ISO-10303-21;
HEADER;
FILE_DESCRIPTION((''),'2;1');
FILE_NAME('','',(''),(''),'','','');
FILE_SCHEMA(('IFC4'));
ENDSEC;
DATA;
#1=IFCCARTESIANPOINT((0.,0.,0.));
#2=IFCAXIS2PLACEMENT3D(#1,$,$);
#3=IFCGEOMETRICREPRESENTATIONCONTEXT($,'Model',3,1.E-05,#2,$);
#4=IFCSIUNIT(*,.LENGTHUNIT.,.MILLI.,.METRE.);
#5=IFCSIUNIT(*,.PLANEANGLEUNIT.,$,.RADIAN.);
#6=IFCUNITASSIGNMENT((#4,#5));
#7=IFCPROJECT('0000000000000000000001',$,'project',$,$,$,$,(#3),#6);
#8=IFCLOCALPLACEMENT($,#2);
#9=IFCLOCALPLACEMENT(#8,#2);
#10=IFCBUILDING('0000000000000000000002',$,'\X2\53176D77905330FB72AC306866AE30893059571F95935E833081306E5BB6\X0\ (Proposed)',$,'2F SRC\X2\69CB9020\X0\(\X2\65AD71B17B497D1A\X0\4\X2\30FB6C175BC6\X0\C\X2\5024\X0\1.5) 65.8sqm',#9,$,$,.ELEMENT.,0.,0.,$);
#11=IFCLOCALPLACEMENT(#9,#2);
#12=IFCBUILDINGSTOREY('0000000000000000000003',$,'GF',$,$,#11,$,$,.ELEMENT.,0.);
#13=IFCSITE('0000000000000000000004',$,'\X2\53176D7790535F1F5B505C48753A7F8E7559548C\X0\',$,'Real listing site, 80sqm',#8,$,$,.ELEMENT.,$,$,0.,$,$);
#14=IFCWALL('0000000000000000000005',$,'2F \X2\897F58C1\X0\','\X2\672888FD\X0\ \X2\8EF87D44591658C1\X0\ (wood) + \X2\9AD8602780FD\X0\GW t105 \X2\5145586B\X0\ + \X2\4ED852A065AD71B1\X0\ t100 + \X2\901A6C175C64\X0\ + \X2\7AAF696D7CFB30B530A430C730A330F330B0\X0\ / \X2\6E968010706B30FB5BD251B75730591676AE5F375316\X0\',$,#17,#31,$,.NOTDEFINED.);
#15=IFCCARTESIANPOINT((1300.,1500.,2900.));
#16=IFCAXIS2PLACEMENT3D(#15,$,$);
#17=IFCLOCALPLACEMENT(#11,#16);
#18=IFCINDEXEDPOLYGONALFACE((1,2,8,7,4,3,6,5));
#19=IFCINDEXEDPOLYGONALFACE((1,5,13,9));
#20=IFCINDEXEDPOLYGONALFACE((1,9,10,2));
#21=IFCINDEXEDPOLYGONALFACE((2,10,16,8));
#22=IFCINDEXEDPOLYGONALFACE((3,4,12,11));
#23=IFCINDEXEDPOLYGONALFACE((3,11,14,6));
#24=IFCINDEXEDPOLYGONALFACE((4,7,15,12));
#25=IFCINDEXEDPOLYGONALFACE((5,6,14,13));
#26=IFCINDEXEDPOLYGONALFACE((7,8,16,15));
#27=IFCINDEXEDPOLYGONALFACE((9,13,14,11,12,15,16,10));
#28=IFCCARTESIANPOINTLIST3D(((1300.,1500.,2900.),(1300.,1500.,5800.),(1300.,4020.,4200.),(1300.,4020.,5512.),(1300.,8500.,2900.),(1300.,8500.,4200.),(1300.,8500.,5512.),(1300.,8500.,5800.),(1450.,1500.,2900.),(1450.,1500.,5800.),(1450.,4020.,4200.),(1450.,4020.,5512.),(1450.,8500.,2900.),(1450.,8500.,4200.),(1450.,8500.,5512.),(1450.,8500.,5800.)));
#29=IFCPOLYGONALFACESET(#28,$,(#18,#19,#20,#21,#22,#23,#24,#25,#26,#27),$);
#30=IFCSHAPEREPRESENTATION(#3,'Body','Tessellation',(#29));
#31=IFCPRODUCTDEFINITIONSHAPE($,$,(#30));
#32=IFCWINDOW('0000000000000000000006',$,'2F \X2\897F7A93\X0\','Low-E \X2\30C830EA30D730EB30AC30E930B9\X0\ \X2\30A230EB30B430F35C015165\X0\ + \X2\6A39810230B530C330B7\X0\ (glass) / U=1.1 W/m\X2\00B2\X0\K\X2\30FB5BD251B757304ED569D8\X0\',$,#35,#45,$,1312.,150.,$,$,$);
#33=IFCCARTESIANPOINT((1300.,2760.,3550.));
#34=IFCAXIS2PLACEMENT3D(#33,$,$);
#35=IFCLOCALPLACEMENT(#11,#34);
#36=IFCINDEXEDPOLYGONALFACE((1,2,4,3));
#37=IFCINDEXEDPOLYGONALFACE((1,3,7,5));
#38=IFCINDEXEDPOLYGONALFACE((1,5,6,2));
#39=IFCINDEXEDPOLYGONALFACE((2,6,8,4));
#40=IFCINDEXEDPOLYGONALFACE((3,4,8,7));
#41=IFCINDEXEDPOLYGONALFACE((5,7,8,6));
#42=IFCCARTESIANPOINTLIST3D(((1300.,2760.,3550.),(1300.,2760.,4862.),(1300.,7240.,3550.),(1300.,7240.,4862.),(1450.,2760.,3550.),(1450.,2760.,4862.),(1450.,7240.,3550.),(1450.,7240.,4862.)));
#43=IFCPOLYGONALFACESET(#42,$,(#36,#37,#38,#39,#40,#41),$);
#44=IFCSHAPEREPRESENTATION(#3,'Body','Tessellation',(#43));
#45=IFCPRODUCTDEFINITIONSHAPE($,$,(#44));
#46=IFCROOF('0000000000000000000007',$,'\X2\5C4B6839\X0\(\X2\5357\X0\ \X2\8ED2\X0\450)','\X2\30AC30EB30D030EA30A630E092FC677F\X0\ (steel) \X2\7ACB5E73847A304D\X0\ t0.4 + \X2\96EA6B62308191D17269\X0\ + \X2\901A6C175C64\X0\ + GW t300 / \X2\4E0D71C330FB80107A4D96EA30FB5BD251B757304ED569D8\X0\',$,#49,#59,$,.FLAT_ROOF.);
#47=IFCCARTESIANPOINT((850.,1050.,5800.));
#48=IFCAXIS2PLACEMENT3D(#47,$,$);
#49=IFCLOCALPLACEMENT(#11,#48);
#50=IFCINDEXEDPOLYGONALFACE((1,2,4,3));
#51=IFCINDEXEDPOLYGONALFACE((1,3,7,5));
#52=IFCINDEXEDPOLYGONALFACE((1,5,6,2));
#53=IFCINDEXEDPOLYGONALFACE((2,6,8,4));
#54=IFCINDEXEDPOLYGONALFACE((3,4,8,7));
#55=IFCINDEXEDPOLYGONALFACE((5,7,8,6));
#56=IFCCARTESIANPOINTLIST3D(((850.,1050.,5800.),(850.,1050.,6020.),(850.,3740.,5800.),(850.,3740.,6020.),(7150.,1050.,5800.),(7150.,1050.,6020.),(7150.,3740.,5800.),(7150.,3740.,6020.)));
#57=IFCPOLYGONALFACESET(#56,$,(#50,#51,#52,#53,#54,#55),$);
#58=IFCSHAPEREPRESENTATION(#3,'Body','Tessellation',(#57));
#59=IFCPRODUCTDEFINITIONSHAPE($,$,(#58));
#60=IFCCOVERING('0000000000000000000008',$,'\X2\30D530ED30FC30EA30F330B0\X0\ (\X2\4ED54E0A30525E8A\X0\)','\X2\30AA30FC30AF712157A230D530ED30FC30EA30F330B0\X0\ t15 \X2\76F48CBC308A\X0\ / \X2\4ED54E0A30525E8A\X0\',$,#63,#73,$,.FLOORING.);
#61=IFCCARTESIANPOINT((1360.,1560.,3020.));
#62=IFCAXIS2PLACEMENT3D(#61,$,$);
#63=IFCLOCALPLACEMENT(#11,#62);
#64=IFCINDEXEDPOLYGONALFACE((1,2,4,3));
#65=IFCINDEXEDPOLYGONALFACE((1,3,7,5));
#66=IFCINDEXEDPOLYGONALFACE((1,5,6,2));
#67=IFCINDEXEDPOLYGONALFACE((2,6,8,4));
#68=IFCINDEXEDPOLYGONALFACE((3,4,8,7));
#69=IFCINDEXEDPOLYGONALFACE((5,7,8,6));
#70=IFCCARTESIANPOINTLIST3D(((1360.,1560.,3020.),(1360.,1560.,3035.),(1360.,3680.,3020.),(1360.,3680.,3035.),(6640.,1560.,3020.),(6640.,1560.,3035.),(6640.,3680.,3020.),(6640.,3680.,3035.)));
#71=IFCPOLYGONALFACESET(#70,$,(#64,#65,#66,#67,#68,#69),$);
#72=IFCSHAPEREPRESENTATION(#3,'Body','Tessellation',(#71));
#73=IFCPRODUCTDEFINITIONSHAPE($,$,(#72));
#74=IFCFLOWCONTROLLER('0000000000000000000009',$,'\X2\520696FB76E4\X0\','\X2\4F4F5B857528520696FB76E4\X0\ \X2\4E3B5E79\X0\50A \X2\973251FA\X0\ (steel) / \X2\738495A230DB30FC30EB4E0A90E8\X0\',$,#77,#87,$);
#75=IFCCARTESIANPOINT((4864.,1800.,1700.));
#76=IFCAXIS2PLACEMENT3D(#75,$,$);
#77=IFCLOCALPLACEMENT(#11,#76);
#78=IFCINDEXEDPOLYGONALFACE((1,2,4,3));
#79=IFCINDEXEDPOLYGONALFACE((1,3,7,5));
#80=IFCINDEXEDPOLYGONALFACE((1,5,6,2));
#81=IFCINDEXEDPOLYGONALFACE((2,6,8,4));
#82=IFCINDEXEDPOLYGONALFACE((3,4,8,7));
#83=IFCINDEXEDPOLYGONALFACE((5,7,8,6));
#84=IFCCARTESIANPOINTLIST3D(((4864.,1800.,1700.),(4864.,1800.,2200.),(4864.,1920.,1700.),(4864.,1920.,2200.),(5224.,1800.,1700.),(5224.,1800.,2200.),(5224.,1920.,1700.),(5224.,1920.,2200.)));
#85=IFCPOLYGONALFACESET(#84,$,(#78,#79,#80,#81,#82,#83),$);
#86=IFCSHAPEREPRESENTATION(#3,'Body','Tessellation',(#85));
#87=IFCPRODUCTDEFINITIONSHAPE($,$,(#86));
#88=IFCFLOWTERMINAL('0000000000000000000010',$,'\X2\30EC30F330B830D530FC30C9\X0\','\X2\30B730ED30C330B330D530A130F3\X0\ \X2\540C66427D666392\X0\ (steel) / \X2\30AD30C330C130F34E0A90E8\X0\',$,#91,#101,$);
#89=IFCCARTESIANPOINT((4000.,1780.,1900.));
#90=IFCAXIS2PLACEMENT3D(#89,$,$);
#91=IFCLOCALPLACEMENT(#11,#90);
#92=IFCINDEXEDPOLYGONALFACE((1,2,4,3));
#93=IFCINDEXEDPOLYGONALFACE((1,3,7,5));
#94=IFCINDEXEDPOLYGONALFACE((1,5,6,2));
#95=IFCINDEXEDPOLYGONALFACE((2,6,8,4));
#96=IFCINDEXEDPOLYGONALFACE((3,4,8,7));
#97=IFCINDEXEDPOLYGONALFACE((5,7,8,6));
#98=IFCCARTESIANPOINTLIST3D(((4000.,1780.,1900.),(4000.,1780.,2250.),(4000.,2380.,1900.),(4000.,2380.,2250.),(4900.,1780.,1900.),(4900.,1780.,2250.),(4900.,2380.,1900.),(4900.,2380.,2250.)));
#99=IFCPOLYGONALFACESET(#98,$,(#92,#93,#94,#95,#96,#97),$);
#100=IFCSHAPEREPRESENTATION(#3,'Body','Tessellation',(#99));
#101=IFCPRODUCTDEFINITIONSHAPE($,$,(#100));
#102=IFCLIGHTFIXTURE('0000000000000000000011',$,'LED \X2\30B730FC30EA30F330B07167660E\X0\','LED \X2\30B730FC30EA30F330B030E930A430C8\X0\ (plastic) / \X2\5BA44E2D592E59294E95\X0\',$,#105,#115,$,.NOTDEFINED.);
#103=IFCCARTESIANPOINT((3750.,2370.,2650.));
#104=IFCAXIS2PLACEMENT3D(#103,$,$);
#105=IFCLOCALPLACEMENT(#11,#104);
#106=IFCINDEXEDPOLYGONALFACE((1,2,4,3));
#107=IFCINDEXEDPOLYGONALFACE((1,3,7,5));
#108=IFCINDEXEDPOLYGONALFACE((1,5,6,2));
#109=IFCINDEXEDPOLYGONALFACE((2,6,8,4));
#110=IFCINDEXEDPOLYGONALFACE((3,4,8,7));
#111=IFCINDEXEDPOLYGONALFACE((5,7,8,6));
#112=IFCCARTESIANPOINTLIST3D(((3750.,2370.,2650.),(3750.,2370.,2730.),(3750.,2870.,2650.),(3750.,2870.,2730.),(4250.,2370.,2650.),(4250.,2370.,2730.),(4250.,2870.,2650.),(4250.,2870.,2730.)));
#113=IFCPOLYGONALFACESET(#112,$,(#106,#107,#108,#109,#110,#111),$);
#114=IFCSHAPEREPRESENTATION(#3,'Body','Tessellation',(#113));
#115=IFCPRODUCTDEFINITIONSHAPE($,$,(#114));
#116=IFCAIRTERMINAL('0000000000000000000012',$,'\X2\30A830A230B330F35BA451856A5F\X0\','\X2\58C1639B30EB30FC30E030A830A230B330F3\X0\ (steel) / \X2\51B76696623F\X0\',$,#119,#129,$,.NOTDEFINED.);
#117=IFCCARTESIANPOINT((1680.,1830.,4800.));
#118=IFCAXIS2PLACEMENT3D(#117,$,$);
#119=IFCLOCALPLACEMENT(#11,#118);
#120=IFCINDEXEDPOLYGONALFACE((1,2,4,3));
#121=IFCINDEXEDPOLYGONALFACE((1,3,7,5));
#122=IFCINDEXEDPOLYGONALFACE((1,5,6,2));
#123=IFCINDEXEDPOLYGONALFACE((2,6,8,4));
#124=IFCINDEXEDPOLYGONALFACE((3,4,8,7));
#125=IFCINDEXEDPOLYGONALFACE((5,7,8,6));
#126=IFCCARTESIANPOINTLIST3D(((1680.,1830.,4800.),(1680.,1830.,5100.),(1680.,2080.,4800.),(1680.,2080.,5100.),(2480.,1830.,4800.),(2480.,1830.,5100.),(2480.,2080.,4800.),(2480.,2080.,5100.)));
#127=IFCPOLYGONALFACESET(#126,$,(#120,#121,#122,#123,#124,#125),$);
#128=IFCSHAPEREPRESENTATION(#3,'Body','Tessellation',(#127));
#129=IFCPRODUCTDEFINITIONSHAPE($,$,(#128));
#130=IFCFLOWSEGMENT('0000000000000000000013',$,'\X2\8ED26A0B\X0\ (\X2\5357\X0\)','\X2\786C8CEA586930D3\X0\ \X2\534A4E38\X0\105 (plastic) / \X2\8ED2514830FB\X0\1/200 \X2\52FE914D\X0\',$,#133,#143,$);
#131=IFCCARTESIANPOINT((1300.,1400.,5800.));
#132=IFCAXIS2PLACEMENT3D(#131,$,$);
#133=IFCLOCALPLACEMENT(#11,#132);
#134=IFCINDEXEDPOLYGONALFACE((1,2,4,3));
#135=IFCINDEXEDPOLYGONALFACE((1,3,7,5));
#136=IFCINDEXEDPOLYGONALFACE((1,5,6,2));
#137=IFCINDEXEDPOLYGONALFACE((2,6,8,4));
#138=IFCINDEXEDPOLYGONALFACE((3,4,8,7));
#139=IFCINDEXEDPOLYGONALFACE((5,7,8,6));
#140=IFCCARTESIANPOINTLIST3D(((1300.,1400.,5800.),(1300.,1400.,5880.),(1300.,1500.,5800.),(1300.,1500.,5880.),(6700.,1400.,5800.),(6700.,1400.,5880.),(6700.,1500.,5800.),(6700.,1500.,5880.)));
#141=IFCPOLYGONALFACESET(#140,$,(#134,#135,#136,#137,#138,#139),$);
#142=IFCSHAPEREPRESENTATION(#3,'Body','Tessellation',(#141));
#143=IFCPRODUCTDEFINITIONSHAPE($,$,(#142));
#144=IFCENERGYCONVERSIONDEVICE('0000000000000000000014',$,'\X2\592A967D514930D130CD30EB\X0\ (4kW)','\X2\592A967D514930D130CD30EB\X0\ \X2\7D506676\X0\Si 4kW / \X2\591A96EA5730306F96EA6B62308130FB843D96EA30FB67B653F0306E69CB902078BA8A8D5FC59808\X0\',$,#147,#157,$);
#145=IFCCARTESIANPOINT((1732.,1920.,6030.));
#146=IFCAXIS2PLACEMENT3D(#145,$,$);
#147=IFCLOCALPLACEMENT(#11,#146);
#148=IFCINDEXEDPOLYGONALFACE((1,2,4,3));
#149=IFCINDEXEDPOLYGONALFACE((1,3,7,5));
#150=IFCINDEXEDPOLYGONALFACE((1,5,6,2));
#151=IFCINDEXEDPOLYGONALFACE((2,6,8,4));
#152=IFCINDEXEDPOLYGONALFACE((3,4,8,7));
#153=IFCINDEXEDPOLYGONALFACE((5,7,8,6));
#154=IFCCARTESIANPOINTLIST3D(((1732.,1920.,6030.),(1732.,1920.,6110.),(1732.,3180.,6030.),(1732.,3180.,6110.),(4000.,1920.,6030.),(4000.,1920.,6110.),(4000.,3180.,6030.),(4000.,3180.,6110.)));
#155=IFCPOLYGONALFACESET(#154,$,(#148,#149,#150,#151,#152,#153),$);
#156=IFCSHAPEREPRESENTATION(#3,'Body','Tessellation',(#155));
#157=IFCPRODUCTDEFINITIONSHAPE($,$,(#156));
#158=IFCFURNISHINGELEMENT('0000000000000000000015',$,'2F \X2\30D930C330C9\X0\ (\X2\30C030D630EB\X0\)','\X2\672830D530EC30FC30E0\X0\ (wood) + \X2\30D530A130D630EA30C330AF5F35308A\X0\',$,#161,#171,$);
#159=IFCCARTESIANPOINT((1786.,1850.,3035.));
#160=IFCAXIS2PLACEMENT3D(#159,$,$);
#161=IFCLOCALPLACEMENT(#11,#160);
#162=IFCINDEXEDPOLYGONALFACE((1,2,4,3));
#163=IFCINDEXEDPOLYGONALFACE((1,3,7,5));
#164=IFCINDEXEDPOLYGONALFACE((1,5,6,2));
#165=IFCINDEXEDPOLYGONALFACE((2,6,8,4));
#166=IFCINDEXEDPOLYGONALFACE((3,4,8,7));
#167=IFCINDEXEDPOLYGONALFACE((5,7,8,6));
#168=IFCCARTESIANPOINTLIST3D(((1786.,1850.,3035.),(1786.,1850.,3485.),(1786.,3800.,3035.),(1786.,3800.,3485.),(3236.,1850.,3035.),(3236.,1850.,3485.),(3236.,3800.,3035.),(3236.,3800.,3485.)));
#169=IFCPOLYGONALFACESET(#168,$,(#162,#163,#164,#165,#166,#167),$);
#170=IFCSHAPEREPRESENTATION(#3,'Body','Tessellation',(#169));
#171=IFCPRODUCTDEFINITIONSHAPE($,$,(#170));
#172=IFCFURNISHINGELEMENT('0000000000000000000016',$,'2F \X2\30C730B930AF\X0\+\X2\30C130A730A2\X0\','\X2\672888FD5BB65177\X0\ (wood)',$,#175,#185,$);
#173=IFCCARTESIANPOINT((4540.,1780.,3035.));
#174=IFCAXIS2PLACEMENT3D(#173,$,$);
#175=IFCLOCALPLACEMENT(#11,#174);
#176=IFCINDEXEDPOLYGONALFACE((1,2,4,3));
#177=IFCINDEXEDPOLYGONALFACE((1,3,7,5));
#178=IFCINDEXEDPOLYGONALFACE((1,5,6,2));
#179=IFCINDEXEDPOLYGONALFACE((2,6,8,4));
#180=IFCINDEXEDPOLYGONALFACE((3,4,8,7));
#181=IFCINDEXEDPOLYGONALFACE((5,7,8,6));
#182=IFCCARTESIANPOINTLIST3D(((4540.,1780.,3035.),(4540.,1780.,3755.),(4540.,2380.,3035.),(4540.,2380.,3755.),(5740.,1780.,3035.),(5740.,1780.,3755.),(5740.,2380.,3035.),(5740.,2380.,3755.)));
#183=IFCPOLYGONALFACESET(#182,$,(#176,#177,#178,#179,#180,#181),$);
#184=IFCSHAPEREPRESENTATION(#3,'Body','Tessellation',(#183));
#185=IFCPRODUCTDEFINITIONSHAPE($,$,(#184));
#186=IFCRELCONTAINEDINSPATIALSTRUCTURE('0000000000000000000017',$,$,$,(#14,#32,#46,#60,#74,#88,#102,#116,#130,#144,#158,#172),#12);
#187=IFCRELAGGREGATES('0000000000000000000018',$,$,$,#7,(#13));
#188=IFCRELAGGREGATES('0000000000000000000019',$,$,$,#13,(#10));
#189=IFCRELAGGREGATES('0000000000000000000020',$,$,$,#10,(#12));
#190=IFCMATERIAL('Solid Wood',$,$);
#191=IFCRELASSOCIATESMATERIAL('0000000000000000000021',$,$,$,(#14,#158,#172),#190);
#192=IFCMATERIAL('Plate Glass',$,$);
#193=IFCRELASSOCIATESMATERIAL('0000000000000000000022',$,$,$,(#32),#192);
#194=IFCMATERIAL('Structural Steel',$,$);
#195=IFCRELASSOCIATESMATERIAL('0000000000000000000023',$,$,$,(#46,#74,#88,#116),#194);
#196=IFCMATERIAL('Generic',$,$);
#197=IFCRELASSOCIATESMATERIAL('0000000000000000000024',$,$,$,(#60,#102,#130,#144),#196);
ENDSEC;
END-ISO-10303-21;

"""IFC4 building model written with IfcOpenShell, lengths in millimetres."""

from ifc_helpers import new_model, si_unit, frame, frame_2d, origin, place, context, project, spatial, rectangle, extrude, material, element, fill, save


model = new_model("IFC4")

# Units and contexts
model_context = context("Model", 3, precision=1e-05, world=origin())
ifc_project = project(units=[si_unit("LENGTHUNIT", "METRE", prefix="MILLI"), si_unit("PLANEANGLEUNIT", "RADIAN")], contexts=[model_context])

# Site, building, storey
site_placement = place(None, origin())
site = spatial("IfcSite", under=ifc_project, at=site_placement, Name="北海道弟子屈町美留和", ObjectType="Real listing site, 80sqm", CompositionType="ELEMENT", RefElevation=0.0)
building_placement = place(site_placement, origin())
building = spatial("IfcBuilding", under=site, at=building_placement, Name="北海道・犬と暮らす土間広めの家 (Proposed)", ObjectType="2F SRC構造(断熱等級4・気密C値1.5) 65.8sqm", CompositionType="ELEMENT", ElevationOfRefHeight=0.0, ElevationOfTerrain=0.0)
storey_placement = place(building_placement, origin())
storey = spatial("IfcBuildingStorey", under=building, at=storey_placement, Name="GF", CompositionType="ELEMENT", Elevation=0.0)

# Shared definitions
ifc_material_1 = material(Name="Solid Wood")

# Wall, opening, window
ifc_material_2 = material(Name="Plate Glass")
wall_1_placement = place(storey_placement, frame((1300.0, 1500.0, 2900.0)))
wall_1 = element("IfcWall", 1, at=wall_1_placement, inside=storey, material=ifc_material_1, Name="2F 西壁", Description="木製 軸組外壁 (wood) + 高性能GW t105 充填 + 付加断熱 t100 + 通気層 + 窯業系サイディング / 準耐火・寒冷地外皮強化", PredefinedType="NOTDEFINED", context=model_context, shape_type="SweptSolid", body=[
    extrude(rectangle(XDim=150.0, YDim=7000.0, at=frame_2d((75.0, 3500.0))), frame((1300.0, 1500.0, 2900.0)), (0.0, 0.0, 1.0), 2900.0),
])
opening_1_placement = place(storey_placement, frame((1300.0, 2760.0, 3550.0)))
opening_1 = element("IfcOpeningElement", 2, at=opening_1_placement, cuts=wall_1, PredefinedType="NOTDEFINED", context=model_context, shape_type="SweptSolid", body=[
    extrude(rectangle(XDim=150.0, YDim=4480.0, at=frame_2d((75.0, 2240.0))), frame((1300.0, 2760.0, 3550.0)), (0.0, 0.0, 1.0), 1312.0),
])
window_1_placement = place(storey_placement, frame((1300.0, 2760.0, 3550.0)))
window_1 = element("IfcWindow", 3, at=window_1_placement, inside=storey, material=ifc_material_2, Name="2F 西窓", Description="Low-E トリプルガラス アルゴン封入 + 樹脂サッシ (glass) / U=1.1 W/m²K・寒冷地仕様", OverallHeight=1312.0, OverallWidth=150.0, context=model_context, shape_type="SweptSolid", body=[
    extrude(rectangle(XDim=150.0, YDim=4480.0, at=frame_2d((75.0, 2240.0))), frame((1300.0, 2760.0, 3550.0)), (0.0, 0.0, 1.0), 1312.0),
])
fill(opening_1, window_1)

# Roof
ifc_material_3 = material(Name="Structural Steel")
for number, where, name in (
    (4, (850.0, 1050.0, 5800.0), "屋根(南 軒450)"),
):
    element("IfcRoof", number, at=place(storey_placement, frame(where)), inside=storey, material=ifc_material_3, Name=name, Description="ガルバリウム鋼板 (steel) 立平葺き t0.4 + 雪止め金物 + 通気層 + GW t300 / 不燃・耐積雪・寒冷地仕様", PredefinedType="FLAT_ROOF", context=model_context, shape_type="SweptSolid", body=[
        extrude(rectangle(XDim=6300.0, YDim=2690.0, at=frame_2d((3150.0, 1345.0))), frame((850.0, 1050.0, 5800.0)), (0.0, 0.0, 1.0), 220.0),
    ])

# Covering
ifc_material_4 = material(Name="Generic")
covering_placement = place(storey_placement, frame((1360.0, 1560.0, 3020.0)))
element("IfcCovering", 5, at=covering_placement, inside=storey, material=ifc_material_4, Name="フローリング (仕上げ床)", Description="オーク無垢フローリング t15 直貼り / 仕上げ床", PredefinedType="FLOORING", context=model_context, shape_type="SweptSolid", body=[
    extrude(rectangle(XDim=5280.0, YDim=2120.0, at=frame_2d((2640.0, 1060.0))), frame((1360.0, 1560.0, 3020.0)), (0.0, 0.0, 1.0), 15.0),
])

# Flow controller
flow_controller_placement = place(storey_placement, frame((4864.0, 1800.0, 1700.0)))
element("IfcFlowController", 6, at=flow_controller_placement, inside=storey, material=ifc_material_3, Name="分電盤", Description="住宅用分電盤 主幹50A 露出 (steel) / 玄関ホール上部", context=model_context, shape_type="SweptSolid", body=[
    extrude(rectangle(XDim=360.0, YDim=120.0, at=frame_2d((180.0, 60.0))), frame((4864.0, 1800.0, 1700.0)), (0.0, 0.0, 1.0), 500.0),
])

# Flow terminal
flow_terminal_placement = place(storey_placement, frame((4000.0, 1780.0, 1900.0)))
element("IfcFlowTerminal", 7, at=flow_terminal_placement, inside=storey, material=ifc_material_3, Name="レンジフード", Description="シロッコファン 同時給排 (steel) / キッチン上部", context=model_context, shape_type="SweptSolid", body=[
    extrude(rectangle(XDim=900.0, YDim=600.0, at=frame_2d((450.0, 300.0))), frame((4000.0, 1780.0, 1900.0)), (0.0, 0.0, 1.0), 350.0),
])

# Light fixture
light_fixture_placement = place(storey_placement, frame((3750.0, 2370.0, 2650.0)))
element("IfcLightFixture", 8, at=light_fixture_placement, inside=storey, material=ifc_material_4, Name="LED シーリング照明", Description="LED シーリングライト (plastic) / 室中央天井", PredefinedType="NOTDEFINED", context=model_context, shape_type="SweptSolid", body=[
    extrude(rectangle(XDim=500.0, YDim=500.0, at=frame_2d((250.0, 250.0))), frame((3750.0, 2370.0, 2650.0)), (0.0, 0.0, 1.0), 80.0),
])

# Air terminal
air_terminal_placement = place(storey_placement, frame((1680.0, 1830.0, 4800.0)))
element("IfcAirTerminal", 9, at=air_terminal_placement, inside=storey, material=ifc_material_3, Name="エアコン室内機", Description="壁掛ルームエアコン (steel) / 冷暖房", PredefinedType="NOTDEFINED", context=model_context, shape_type="SweptSolid", body=[
    extrude(rectangle(XDim=800.0, YDim=250.0, at=frame_2d((400.0, 125.0))), frame((1680.0, 1830.0, 4800.0)), (0.0, 0.0, 1.0), 300.0),
])

# Flow segment
flow_segment_placement = place(storey_placement, frame((1300.0, 1400.0, 5800.0)))
element("IfcFlowSegment", 10, at=flow_segment_placement, inside=storey, material=ifc_material_4, Name="軒樋 (南)", Description="硬質塩ビ 半丸105 (plastic) / 軒先・1/200 勾配", context=model_context, shape_type="SweptSolid", body=[
    extrude(rectangle(XDim=5400.0, YDim=100.0, at=frame_2d((2700.0, 50.0))), frame((1300.0, 1400.0, 5800.0)), (0.0, 0.0, 1.0), 80.0),
])

# Energy conversion device
energy_conversion_device_placement = place(storey_placement, frame((1732.0, 1920.0, 6030.0)))
element("IfcEnergyConversionDevice", 11, at=energy_conversion_device_placement, inside=storey, material=ifc_material_4, Name="太陽光パネル (4kW)", Description="太陽光パネル 結晶Si 4kW / 多雪地は雪止め・落雪・架台の構造確認必須", context=model_context, shape_type="SweptSolid", body=[
    extrude(rectangle(XDim=2268.0, YDim=1260.0, at=frame_2d((1134.0, 630.0))), frame((1732.0, 1920.0, 6030.0)), (0.0, 0.0, 1.0), 80.0),
])

# Furnishing elements
furnishing_1_placement = place(storey_placement, frame((1786.0, 1850.0, 3035.0)))
element("IfcFurnishingElement", 12, at=furnishing_1_placement, inside=storey, material=ifc_material_1, Name="2F ベッド (ダブル)", Description="木フレーム (wood) + ファブリック張り", context=model_context, shape_type="SweptSolid", body=[
    extrude(rectangle(XDim=1450.0, YDim=1950.0, at=frame_2d((725.0, 975.0))), frame((1786.0, 1850.0, 3035.0)), (0.0, 0.0, 1.0), 450.0),
])
furnishing_2_placement = place(storey_placement, frame((4540.0, 1780.0, 3035.0)))
element("IfcFurnishingElement", 13, at=furnishing_2_placement, inside=storey, material=ifc_material_1, Name="2F デスク+チェア", Description="木製家具 (wood)", context=model_context, shape_type="SweptSolid", body=[
    extrude(rectangle(XDim=1200.0, YDim=600.0, at=frame_2d((600.0, 300.0))), frame((4540.0, 1780.0, 3035.0)), (0.0, 0.0, 1.0), 720.0),
])

save(model, "model.ifc")
